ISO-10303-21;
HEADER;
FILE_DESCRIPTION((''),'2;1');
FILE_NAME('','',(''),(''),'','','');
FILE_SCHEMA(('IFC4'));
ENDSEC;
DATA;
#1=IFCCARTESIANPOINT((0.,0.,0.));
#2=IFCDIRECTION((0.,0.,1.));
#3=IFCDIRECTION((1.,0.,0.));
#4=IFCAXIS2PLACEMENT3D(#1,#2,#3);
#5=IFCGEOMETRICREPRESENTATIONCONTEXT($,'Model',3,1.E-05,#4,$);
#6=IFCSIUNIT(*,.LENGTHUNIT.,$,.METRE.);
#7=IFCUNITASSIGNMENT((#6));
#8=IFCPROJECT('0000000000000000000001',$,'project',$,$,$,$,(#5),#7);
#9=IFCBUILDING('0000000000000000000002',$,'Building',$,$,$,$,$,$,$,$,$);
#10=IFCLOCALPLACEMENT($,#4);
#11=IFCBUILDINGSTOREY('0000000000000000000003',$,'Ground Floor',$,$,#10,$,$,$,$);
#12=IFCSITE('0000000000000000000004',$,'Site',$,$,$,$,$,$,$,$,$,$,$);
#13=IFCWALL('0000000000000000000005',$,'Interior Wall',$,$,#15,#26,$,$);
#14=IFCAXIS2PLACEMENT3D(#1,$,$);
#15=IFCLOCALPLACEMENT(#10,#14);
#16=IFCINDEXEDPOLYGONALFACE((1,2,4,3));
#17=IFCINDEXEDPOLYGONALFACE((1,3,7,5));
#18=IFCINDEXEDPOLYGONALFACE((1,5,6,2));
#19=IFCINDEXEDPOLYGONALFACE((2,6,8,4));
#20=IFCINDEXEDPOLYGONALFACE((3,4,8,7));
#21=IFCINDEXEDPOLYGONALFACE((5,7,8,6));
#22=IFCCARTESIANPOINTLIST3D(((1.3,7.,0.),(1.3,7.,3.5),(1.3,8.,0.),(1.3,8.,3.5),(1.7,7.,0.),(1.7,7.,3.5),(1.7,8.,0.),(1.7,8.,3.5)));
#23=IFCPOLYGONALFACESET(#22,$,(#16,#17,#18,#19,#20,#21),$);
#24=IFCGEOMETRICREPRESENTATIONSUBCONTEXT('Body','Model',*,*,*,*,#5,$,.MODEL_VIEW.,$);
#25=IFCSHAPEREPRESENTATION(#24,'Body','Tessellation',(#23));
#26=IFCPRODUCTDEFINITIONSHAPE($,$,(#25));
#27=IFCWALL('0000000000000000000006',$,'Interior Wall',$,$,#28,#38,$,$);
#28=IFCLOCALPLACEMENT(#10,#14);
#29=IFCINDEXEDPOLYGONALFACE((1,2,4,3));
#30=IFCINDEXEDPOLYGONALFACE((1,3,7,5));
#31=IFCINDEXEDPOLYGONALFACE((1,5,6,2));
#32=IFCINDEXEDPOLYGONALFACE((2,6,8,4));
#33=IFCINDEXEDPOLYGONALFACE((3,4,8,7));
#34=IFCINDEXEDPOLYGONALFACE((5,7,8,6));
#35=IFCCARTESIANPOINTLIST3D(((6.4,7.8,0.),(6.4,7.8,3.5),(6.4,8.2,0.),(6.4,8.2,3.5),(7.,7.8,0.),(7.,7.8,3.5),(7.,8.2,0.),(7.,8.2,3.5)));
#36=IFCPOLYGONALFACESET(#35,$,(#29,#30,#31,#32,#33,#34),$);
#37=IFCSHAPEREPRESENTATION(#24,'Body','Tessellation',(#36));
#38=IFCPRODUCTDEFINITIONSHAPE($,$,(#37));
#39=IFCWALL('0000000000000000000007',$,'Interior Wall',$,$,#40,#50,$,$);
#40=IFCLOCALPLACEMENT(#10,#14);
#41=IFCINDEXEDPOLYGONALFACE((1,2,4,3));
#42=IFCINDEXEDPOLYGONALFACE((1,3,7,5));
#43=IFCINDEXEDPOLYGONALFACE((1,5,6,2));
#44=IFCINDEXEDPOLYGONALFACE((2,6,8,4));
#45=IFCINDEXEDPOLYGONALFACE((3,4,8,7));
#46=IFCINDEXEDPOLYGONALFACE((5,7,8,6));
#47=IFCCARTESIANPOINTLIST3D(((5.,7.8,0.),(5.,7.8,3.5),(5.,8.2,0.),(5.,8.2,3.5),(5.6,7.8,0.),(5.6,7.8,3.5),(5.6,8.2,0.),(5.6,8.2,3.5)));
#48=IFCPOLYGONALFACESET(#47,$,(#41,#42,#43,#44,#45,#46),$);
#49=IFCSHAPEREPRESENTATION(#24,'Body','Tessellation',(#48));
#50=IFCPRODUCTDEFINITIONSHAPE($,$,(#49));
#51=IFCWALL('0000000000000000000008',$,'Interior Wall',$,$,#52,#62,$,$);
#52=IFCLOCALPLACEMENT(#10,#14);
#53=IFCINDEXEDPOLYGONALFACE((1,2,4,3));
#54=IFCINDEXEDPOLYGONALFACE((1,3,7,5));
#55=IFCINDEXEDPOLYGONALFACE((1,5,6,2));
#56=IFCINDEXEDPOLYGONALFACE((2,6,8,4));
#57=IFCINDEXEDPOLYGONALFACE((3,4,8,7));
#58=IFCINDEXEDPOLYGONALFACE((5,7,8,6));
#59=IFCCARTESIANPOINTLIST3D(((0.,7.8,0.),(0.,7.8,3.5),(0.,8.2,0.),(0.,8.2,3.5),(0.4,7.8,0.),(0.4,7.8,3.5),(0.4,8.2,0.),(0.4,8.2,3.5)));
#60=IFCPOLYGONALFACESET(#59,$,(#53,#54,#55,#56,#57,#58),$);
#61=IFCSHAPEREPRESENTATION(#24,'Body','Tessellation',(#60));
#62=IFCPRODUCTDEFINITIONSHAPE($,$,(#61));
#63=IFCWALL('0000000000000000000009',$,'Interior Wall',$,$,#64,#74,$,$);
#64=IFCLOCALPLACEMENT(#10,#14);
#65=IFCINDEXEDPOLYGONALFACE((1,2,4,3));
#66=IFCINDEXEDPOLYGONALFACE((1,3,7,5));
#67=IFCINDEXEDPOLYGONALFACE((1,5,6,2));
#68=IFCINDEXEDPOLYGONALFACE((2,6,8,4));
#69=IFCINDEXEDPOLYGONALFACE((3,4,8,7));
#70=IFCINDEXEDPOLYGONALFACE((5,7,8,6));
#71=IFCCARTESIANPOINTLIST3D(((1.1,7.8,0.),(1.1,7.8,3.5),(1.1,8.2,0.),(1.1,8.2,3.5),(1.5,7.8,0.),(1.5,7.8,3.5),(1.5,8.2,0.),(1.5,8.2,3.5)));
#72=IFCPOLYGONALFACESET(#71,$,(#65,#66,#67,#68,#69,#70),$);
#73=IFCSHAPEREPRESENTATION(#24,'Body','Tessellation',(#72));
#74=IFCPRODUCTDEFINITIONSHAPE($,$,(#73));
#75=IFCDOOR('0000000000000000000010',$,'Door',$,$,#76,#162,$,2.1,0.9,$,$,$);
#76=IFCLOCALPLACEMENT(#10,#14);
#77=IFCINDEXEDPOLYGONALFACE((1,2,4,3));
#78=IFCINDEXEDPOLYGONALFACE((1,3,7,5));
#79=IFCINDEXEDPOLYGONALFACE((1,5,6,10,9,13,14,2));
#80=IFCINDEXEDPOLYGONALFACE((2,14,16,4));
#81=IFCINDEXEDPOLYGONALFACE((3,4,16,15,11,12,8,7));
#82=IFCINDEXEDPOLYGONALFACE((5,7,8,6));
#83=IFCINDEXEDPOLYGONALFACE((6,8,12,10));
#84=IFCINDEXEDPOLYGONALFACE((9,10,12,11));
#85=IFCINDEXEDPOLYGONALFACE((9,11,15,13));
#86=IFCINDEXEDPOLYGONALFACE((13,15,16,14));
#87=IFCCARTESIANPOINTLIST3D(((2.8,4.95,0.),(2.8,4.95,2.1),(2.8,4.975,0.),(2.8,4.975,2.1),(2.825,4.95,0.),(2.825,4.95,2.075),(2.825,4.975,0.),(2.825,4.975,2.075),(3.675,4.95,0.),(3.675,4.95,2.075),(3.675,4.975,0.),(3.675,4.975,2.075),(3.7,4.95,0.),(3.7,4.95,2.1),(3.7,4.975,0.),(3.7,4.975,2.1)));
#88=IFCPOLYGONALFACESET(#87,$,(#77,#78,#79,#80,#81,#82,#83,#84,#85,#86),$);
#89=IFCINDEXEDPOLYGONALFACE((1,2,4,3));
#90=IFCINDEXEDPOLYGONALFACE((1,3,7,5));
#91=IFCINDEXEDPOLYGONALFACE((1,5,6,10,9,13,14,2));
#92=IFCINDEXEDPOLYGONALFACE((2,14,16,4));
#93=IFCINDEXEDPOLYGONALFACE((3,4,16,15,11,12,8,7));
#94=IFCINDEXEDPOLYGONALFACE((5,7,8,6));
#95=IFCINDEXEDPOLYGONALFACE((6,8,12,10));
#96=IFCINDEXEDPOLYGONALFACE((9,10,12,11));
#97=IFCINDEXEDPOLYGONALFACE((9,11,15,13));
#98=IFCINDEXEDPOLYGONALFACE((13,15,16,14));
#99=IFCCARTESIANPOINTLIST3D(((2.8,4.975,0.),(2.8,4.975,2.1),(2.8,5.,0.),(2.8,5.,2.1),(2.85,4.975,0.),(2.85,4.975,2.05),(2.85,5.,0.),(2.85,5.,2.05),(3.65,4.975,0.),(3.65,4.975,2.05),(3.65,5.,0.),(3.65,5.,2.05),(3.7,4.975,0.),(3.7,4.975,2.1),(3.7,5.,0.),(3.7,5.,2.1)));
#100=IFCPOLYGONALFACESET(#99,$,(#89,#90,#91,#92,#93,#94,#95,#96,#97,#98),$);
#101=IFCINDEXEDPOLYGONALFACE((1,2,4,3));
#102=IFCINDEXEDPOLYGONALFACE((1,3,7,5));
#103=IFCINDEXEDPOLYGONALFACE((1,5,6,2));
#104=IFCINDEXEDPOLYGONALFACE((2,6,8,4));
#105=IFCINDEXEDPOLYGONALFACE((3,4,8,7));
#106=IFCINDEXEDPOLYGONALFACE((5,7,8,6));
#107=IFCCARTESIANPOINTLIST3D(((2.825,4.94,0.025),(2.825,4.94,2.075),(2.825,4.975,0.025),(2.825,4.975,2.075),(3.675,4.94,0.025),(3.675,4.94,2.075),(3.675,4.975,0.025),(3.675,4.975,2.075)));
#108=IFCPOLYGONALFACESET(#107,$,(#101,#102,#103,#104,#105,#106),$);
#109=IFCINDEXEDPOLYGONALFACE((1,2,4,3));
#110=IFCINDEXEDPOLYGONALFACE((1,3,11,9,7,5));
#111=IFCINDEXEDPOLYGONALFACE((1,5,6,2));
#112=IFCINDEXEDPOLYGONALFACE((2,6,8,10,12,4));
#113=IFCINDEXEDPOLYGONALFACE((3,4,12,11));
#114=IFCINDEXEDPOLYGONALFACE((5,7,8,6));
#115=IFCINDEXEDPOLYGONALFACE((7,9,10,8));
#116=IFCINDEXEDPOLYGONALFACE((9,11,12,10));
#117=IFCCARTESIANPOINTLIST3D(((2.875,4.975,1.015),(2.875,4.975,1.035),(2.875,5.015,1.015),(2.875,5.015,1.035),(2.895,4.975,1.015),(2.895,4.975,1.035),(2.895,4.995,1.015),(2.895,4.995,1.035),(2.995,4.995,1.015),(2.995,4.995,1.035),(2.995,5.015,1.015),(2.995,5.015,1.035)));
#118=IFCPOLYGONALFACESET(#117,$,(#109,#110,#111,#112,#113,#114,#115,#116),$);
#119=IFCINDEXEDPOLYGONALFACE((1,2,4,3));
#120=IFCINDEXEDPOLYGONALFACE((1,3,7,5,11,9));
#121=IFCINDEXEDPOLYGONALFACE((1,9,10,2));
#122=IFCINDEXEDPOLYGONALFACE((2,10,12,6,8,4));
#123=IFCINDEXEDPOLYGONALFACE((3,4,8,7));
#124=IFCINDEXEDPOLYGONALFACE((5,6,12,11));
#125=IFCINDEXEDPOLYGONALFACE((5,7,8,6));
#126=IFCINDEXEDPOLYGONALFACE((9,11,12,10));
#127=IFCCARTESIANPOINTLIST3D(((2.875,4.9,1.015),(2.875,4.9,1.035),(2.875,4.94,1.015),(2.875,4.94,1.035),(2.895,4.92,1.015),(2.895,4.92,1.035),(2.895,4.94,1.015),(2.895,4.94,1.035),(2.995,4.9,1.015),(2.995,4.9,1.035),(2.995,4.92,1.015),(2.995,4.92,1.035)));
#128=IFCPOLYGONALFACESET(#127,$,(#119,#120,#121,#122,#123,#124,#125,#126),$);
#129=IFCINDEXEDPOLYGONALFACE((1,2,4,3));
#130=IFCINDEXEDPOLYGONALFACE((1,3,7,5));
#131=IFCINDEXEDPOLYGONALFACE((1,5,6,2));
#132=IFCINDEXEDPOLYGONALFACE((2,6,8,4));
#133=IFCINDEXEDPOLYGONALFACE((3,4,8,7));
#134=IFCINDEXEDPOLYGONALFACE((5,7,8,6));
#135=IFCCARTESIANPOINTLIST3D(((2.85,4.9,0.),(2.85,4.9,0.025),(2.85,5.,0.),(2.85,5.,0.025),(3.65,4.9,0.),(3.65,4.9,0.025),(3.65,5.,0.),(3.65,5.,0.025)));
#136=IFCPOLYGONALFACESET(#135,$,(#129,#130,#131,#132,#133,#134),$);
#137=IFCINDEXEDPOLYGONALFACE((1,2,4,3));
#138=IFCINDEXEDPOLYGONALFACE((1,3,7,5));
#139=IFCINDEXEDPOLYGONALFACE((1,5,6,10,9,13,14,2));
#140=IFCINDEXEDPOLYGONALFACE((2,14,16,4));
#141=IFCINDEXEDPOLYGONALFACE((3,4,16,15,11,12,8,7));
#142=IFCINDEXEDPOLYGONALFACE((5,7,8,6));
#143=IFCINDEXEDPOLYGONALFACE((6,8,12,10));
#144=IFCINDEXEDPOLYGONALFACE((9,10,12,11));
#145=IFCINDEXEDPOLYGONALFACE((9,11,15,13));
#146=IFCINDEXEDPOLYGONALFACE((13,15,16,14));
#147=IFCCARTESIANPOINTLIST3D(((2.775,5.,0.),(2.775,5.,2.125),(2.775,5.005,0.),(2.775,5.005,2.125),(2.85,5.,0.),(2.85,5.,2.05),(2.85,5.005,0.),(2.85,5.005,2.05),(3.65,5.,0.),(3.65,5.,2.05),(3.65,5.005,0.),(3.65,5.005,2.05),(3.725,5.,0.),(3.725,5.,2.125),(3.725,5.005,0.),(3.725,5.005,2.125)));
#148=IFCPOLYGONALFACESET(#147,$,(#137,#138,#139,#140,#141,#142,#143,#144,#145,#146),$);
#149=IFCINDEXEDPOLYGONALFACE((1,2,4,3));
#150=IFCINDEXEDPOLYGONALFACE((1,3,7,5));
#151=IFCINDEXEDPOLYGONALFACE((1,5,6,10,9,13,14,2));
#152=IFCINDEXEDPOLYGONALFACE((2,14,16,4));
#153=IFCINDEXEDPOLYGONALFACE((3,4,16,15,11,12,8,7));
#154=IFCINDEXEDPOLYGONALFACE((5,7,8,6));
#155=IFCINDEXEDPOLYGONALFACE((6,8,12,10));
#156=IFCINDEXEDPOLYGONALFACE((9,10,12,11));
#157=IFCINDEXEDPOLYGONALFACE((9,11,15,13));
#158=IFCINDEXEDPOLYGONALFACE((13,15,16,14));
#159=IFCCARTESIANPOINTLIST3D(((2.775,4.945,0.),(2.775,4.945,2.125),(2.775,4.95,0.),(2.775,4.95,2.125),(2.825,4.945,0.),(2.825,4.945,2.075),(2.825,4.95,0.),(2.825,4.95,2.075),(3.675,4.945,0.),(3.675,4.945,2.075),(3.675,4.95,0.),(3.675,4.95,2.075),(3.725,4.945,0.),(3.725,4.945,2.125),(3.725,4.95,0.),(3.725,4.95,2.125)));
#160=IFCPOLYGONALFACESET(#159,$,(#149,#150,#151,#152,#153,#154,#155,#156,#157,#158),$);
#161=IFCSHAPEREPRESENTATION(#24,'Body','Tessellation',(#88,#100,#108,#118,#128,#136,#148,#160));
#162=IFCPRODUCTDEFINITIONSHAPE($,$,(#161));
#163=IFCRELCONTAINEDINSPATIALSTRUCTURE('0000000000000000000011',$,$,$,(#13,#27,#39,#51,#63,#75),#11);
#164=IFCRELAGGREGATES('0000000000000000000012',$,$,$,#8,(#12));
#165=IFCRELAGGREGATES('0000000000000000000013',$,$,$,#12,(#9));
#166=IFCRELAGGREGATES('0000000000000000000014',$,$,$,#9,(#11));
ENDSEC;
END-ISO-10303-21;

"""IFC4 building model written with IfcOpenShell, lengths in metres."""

from ifc_helpers import new_model, si_unit, frame, origin_with_axes, place, context, subcontext, project, spatial, line, indexed_curve, outline, extrude, element, save


model = new_model("IFC4")

# Units and contexts
model_context = context("Model", 3, precision=1e-05, world=origin_with_axes())
body_context = subcontext(model_context, "Body", "Model", "MODEL_VIEW")
ifc_project = project(units=[si_unit("LENGTHUNIT", "METRE")], contexts=[model_context])

# Site, building, storey
site = spatial("IfcSite", under=ifc_project, Name="Site")
building = spatial("IfcBuilding", under=site, Name="Building")
storey_placement = place(None, origin_with_axes())
storey = spatial("IfcBuildingStorey", under=building, at=storey_placement, Name="Ground Floor")

# Walls
wall_1_placement = place(storey_placement, frame((1.5, 8.0, 0.0), z_axis=(0.0, 0.0, 1.0), x_axis=(0.0, -1.0, 0.0)))
element("IfcWall", 1, at=wall_1_placement, inside=storey, Name="Interior Wall", context=body_context, shape_type="SweptSolid", body=[
    extrude(outline(indexed_curve([(0.0, 0.0), (0.0, 0.4), (1.0, 0.4), (1.0, 0.0), (0.0, 0.0)], self_intersect=False)), frame((0.0, -0.2, 0.0), z_axis=(0.0, 0.0, 1.0), x_axis=(1.0, 0.0, 0.0)), (0.0, 0.0, 1.0), 3.5),
])
for number, where, z_axis, x_axis, name in (
    (2, (7.0, 8.0, 0.0), (0.0, 0.0, 1.0), (-1.0, 0.0, 0.0), "Interior Wall"),
    (3, (5.6, 8.0, 0.0), (0.0, 0.0, 1.0), (-1.0, 0.0, 0.0), "Interior Wall"),
):
    element("IfcWall", number, at=place(storey_placement, frame(where, z_axis=z_axis, x_axis=x_axis)), inside=storey, Name=name, context=body_context, shape_type="SweptSolid", body=[
        extrude(outline(indexed_curve([(0.0, 0.0), (0.0, 0.4), (0.6, 0.4), (0.6, 0.0), (0.0, 0.0)], self_intersect=False)), frame((0.0, -0.2, 0.0), z_axis=(0.0, 0.0, 1.0), x_axis=(1.0, 0.0, 0.0)), (0.0, 0.0, 1.0), 3.5),
    ])
wall_2_placement = place(storey_placement, frame((0.0, 8.0, 0.0), z_axis=(0.0, 0.0, 1.0), x_axis=(1.0, 0.0, 0.0)))
element("IfcWall", 4, at=wall_2_placement, inside=storey, Name="Interior Wall", context=body_context, shape_type="SweptSolid", body=[
    extrude(outline(indexed_curve([(0.0, 0.0), (0.0, 0.4), (0.4, 0.4), (0.4, 0.0), (0.0, 0.0)], self_intersect=False)), frame((0.0, -0.2, 0.0), z_axis=(0.0, 0.0, 1.0), x_axis=(1.0, 0.0, 0.0)), (0.0, 0.0, 1.0), 3.5),
])
wall_3_placement = place(storey_placement, frame((1.1, 8.0, 0.0), z_axis=(0.0, 0.0, 1.0), x_axis=(1.0, 0.0, 0.0)))
element("IfcWall", 5, at=wall_3_placement, inside=storey, Name="Interior Wall", context=body_context, shape_type="SweptSolid", body=[
    extrude(outline(indexed_curve([(0.0, 0.0), (0.0, 0.4), (0.4, 0.4), (0.4, 0.0), (0.0, 0.0)], self_intersect=False)), frame((0.0, -0.2, 0.0), z_axis=(0.0, 0.0, 1.0), x_axis=(1.0, 0.0, 0.0)), (0.0, 0.0, 1.0), 3.5),
])

# Door
door_1_placement = place(storey_placement, frame((3.7, 5.0, 0.0), z_axis=(0.0, 0.0, 1.0), x_axis=(-1.0, 0.0, 0.0)))
element("IfcDoor", 6, at=door_1_placement, inside=storey, Name="Door", OverallHeight=2.1, OverallWidth=0.9, context=body_context, shape_type="SweptSolid", body=[
    extrude(outline(indexed_curve([(0.0, 0.0), (0.0, 2.1), (0.9, 2.1), (0.9, 0.0), (0.875, 0.0), (0.875, 2.075), (0.025, 2.075), (0.025, 0.0)], segments=[line(1, 2, 3, 4, 5, 6, 7, 8, 1)])), frame((0.0, 0.025, 0.0), z_axis=(0.0, -1.0, 0.0), x_axis=(1.0, 0.0, 0.0)), (0.0, 0.0, -1.0), 0.025),
    extrude(outline(indexed_curve([(0.0, 0.0), (0.0, 2.1), (0.9, 2.1), (0.9, 0.0), (0.85, 0.0), (0.85, 2.05), (0.05, 2.05), (0.05, 0.0)], segments=[line(1, 2, 3, 4, 5, 6, 7, 8, 1)])), frame((0.0, 0.0, 0.0), z_axis=(0.0, -1.0, 0.0), x_axis=(1.0, 0.0, 0.0)), (0.0, 0.0, -1.0), 0.025),
    extrude(outline(indexed_curve([(0.0, 0.0), (0.85, 0.0), (0.85, 0.035), (0.0, 0.035)], segments=[line(1, 2, 3, 4, 1)])), frame((0.025, 0.025, 0.025), z_axis=(0.0, 0.0, 1.0), x_axis=(1.0, 0.0, 0.0)), (0.0, 0.0, 1.0), 2.05),
    extrude(outline(indexed_curve([(0.0, 0.0), (0.0, -0.04), (-0.12, -0.04), (-0.12, -0.02), (-0.02, -0.02), (-0.02, 0.0)], segments=[line(1, 2, 3, 4, 5, 6, 1)])), frame((0.825, 0.025, 1.015), z_axis=(0.0, 0.0, 1.0), x_axis=(1.0, 0.0, 0.0)), (0.0, 0.0, 1.0), 0.02),
    extrude(outline(indexed_curve([(0.0, 0.0), (0.0, 0.04), (-0.12, 0.04), (-0.12, 0.02), (-0.02, 0.02), (-0.02, 0.0)], segments=[line(1, 2, 3, 4, 5, 6, 1)])), frame((0.825, 0.06, 1.015), z_axis=(0.0, 0.0, 1.0), x_axis=(1.0, 0.0, 0.0)), (0.0, 0.0, 1.0), 0.02),
    extrude(outline(indexed_curve([(0.0, 0.0), (0.8, 0.0), (0.8, 0.1), (0.0, 0.1)], segments=[line(1, 2, 3, 4, 1)])), frame((0.05, 0.0, 0.0), z_axis=(0.0, 0.0, 1.0), x_axis=(1.0, 0.0, 0.0)), (0.0, 0.0, 1.0), 0.025),
    extrude(outline(indexed_curve([(0.0, 0.0), (0.0, 2.125), (0.95, 2.125), (0.95, 0.0), (0.875, 0.0), (0.875, 2.05), (0.075, 2.05), (0.075, 0.0)], segments=[line(1, 2, 3, 4, 5, 6, 7, 8, 1)])), frame((-0.025, -0.005, 0.0), z_axis=(0.0, -1.0, 0.0), x_axis=(1.0, 0.0, 0.0)), (0.0, 0.0, -1.0), 0.005),
    extrude(outline(indexed_curve([(0.0, 0.0), (0.0, 2.125), (0.95, 2.125), (0.95, 0.0), (0.9, 0.0), (0.9, 2.075), (0.05, 2.075), (0.05, 0.0)], segments=[line(1, 2, 3, 4, 5, 6, 7, 8, 1)])), frame((-0.025, 0.05, 0.0), z_axis=(0.0, -1.0, 0.0), x_axis=(1.0, 0.0, 0.0)), (0.0, 0.0, -1.0), 0.005),
])

save(model, "model.ifc")
